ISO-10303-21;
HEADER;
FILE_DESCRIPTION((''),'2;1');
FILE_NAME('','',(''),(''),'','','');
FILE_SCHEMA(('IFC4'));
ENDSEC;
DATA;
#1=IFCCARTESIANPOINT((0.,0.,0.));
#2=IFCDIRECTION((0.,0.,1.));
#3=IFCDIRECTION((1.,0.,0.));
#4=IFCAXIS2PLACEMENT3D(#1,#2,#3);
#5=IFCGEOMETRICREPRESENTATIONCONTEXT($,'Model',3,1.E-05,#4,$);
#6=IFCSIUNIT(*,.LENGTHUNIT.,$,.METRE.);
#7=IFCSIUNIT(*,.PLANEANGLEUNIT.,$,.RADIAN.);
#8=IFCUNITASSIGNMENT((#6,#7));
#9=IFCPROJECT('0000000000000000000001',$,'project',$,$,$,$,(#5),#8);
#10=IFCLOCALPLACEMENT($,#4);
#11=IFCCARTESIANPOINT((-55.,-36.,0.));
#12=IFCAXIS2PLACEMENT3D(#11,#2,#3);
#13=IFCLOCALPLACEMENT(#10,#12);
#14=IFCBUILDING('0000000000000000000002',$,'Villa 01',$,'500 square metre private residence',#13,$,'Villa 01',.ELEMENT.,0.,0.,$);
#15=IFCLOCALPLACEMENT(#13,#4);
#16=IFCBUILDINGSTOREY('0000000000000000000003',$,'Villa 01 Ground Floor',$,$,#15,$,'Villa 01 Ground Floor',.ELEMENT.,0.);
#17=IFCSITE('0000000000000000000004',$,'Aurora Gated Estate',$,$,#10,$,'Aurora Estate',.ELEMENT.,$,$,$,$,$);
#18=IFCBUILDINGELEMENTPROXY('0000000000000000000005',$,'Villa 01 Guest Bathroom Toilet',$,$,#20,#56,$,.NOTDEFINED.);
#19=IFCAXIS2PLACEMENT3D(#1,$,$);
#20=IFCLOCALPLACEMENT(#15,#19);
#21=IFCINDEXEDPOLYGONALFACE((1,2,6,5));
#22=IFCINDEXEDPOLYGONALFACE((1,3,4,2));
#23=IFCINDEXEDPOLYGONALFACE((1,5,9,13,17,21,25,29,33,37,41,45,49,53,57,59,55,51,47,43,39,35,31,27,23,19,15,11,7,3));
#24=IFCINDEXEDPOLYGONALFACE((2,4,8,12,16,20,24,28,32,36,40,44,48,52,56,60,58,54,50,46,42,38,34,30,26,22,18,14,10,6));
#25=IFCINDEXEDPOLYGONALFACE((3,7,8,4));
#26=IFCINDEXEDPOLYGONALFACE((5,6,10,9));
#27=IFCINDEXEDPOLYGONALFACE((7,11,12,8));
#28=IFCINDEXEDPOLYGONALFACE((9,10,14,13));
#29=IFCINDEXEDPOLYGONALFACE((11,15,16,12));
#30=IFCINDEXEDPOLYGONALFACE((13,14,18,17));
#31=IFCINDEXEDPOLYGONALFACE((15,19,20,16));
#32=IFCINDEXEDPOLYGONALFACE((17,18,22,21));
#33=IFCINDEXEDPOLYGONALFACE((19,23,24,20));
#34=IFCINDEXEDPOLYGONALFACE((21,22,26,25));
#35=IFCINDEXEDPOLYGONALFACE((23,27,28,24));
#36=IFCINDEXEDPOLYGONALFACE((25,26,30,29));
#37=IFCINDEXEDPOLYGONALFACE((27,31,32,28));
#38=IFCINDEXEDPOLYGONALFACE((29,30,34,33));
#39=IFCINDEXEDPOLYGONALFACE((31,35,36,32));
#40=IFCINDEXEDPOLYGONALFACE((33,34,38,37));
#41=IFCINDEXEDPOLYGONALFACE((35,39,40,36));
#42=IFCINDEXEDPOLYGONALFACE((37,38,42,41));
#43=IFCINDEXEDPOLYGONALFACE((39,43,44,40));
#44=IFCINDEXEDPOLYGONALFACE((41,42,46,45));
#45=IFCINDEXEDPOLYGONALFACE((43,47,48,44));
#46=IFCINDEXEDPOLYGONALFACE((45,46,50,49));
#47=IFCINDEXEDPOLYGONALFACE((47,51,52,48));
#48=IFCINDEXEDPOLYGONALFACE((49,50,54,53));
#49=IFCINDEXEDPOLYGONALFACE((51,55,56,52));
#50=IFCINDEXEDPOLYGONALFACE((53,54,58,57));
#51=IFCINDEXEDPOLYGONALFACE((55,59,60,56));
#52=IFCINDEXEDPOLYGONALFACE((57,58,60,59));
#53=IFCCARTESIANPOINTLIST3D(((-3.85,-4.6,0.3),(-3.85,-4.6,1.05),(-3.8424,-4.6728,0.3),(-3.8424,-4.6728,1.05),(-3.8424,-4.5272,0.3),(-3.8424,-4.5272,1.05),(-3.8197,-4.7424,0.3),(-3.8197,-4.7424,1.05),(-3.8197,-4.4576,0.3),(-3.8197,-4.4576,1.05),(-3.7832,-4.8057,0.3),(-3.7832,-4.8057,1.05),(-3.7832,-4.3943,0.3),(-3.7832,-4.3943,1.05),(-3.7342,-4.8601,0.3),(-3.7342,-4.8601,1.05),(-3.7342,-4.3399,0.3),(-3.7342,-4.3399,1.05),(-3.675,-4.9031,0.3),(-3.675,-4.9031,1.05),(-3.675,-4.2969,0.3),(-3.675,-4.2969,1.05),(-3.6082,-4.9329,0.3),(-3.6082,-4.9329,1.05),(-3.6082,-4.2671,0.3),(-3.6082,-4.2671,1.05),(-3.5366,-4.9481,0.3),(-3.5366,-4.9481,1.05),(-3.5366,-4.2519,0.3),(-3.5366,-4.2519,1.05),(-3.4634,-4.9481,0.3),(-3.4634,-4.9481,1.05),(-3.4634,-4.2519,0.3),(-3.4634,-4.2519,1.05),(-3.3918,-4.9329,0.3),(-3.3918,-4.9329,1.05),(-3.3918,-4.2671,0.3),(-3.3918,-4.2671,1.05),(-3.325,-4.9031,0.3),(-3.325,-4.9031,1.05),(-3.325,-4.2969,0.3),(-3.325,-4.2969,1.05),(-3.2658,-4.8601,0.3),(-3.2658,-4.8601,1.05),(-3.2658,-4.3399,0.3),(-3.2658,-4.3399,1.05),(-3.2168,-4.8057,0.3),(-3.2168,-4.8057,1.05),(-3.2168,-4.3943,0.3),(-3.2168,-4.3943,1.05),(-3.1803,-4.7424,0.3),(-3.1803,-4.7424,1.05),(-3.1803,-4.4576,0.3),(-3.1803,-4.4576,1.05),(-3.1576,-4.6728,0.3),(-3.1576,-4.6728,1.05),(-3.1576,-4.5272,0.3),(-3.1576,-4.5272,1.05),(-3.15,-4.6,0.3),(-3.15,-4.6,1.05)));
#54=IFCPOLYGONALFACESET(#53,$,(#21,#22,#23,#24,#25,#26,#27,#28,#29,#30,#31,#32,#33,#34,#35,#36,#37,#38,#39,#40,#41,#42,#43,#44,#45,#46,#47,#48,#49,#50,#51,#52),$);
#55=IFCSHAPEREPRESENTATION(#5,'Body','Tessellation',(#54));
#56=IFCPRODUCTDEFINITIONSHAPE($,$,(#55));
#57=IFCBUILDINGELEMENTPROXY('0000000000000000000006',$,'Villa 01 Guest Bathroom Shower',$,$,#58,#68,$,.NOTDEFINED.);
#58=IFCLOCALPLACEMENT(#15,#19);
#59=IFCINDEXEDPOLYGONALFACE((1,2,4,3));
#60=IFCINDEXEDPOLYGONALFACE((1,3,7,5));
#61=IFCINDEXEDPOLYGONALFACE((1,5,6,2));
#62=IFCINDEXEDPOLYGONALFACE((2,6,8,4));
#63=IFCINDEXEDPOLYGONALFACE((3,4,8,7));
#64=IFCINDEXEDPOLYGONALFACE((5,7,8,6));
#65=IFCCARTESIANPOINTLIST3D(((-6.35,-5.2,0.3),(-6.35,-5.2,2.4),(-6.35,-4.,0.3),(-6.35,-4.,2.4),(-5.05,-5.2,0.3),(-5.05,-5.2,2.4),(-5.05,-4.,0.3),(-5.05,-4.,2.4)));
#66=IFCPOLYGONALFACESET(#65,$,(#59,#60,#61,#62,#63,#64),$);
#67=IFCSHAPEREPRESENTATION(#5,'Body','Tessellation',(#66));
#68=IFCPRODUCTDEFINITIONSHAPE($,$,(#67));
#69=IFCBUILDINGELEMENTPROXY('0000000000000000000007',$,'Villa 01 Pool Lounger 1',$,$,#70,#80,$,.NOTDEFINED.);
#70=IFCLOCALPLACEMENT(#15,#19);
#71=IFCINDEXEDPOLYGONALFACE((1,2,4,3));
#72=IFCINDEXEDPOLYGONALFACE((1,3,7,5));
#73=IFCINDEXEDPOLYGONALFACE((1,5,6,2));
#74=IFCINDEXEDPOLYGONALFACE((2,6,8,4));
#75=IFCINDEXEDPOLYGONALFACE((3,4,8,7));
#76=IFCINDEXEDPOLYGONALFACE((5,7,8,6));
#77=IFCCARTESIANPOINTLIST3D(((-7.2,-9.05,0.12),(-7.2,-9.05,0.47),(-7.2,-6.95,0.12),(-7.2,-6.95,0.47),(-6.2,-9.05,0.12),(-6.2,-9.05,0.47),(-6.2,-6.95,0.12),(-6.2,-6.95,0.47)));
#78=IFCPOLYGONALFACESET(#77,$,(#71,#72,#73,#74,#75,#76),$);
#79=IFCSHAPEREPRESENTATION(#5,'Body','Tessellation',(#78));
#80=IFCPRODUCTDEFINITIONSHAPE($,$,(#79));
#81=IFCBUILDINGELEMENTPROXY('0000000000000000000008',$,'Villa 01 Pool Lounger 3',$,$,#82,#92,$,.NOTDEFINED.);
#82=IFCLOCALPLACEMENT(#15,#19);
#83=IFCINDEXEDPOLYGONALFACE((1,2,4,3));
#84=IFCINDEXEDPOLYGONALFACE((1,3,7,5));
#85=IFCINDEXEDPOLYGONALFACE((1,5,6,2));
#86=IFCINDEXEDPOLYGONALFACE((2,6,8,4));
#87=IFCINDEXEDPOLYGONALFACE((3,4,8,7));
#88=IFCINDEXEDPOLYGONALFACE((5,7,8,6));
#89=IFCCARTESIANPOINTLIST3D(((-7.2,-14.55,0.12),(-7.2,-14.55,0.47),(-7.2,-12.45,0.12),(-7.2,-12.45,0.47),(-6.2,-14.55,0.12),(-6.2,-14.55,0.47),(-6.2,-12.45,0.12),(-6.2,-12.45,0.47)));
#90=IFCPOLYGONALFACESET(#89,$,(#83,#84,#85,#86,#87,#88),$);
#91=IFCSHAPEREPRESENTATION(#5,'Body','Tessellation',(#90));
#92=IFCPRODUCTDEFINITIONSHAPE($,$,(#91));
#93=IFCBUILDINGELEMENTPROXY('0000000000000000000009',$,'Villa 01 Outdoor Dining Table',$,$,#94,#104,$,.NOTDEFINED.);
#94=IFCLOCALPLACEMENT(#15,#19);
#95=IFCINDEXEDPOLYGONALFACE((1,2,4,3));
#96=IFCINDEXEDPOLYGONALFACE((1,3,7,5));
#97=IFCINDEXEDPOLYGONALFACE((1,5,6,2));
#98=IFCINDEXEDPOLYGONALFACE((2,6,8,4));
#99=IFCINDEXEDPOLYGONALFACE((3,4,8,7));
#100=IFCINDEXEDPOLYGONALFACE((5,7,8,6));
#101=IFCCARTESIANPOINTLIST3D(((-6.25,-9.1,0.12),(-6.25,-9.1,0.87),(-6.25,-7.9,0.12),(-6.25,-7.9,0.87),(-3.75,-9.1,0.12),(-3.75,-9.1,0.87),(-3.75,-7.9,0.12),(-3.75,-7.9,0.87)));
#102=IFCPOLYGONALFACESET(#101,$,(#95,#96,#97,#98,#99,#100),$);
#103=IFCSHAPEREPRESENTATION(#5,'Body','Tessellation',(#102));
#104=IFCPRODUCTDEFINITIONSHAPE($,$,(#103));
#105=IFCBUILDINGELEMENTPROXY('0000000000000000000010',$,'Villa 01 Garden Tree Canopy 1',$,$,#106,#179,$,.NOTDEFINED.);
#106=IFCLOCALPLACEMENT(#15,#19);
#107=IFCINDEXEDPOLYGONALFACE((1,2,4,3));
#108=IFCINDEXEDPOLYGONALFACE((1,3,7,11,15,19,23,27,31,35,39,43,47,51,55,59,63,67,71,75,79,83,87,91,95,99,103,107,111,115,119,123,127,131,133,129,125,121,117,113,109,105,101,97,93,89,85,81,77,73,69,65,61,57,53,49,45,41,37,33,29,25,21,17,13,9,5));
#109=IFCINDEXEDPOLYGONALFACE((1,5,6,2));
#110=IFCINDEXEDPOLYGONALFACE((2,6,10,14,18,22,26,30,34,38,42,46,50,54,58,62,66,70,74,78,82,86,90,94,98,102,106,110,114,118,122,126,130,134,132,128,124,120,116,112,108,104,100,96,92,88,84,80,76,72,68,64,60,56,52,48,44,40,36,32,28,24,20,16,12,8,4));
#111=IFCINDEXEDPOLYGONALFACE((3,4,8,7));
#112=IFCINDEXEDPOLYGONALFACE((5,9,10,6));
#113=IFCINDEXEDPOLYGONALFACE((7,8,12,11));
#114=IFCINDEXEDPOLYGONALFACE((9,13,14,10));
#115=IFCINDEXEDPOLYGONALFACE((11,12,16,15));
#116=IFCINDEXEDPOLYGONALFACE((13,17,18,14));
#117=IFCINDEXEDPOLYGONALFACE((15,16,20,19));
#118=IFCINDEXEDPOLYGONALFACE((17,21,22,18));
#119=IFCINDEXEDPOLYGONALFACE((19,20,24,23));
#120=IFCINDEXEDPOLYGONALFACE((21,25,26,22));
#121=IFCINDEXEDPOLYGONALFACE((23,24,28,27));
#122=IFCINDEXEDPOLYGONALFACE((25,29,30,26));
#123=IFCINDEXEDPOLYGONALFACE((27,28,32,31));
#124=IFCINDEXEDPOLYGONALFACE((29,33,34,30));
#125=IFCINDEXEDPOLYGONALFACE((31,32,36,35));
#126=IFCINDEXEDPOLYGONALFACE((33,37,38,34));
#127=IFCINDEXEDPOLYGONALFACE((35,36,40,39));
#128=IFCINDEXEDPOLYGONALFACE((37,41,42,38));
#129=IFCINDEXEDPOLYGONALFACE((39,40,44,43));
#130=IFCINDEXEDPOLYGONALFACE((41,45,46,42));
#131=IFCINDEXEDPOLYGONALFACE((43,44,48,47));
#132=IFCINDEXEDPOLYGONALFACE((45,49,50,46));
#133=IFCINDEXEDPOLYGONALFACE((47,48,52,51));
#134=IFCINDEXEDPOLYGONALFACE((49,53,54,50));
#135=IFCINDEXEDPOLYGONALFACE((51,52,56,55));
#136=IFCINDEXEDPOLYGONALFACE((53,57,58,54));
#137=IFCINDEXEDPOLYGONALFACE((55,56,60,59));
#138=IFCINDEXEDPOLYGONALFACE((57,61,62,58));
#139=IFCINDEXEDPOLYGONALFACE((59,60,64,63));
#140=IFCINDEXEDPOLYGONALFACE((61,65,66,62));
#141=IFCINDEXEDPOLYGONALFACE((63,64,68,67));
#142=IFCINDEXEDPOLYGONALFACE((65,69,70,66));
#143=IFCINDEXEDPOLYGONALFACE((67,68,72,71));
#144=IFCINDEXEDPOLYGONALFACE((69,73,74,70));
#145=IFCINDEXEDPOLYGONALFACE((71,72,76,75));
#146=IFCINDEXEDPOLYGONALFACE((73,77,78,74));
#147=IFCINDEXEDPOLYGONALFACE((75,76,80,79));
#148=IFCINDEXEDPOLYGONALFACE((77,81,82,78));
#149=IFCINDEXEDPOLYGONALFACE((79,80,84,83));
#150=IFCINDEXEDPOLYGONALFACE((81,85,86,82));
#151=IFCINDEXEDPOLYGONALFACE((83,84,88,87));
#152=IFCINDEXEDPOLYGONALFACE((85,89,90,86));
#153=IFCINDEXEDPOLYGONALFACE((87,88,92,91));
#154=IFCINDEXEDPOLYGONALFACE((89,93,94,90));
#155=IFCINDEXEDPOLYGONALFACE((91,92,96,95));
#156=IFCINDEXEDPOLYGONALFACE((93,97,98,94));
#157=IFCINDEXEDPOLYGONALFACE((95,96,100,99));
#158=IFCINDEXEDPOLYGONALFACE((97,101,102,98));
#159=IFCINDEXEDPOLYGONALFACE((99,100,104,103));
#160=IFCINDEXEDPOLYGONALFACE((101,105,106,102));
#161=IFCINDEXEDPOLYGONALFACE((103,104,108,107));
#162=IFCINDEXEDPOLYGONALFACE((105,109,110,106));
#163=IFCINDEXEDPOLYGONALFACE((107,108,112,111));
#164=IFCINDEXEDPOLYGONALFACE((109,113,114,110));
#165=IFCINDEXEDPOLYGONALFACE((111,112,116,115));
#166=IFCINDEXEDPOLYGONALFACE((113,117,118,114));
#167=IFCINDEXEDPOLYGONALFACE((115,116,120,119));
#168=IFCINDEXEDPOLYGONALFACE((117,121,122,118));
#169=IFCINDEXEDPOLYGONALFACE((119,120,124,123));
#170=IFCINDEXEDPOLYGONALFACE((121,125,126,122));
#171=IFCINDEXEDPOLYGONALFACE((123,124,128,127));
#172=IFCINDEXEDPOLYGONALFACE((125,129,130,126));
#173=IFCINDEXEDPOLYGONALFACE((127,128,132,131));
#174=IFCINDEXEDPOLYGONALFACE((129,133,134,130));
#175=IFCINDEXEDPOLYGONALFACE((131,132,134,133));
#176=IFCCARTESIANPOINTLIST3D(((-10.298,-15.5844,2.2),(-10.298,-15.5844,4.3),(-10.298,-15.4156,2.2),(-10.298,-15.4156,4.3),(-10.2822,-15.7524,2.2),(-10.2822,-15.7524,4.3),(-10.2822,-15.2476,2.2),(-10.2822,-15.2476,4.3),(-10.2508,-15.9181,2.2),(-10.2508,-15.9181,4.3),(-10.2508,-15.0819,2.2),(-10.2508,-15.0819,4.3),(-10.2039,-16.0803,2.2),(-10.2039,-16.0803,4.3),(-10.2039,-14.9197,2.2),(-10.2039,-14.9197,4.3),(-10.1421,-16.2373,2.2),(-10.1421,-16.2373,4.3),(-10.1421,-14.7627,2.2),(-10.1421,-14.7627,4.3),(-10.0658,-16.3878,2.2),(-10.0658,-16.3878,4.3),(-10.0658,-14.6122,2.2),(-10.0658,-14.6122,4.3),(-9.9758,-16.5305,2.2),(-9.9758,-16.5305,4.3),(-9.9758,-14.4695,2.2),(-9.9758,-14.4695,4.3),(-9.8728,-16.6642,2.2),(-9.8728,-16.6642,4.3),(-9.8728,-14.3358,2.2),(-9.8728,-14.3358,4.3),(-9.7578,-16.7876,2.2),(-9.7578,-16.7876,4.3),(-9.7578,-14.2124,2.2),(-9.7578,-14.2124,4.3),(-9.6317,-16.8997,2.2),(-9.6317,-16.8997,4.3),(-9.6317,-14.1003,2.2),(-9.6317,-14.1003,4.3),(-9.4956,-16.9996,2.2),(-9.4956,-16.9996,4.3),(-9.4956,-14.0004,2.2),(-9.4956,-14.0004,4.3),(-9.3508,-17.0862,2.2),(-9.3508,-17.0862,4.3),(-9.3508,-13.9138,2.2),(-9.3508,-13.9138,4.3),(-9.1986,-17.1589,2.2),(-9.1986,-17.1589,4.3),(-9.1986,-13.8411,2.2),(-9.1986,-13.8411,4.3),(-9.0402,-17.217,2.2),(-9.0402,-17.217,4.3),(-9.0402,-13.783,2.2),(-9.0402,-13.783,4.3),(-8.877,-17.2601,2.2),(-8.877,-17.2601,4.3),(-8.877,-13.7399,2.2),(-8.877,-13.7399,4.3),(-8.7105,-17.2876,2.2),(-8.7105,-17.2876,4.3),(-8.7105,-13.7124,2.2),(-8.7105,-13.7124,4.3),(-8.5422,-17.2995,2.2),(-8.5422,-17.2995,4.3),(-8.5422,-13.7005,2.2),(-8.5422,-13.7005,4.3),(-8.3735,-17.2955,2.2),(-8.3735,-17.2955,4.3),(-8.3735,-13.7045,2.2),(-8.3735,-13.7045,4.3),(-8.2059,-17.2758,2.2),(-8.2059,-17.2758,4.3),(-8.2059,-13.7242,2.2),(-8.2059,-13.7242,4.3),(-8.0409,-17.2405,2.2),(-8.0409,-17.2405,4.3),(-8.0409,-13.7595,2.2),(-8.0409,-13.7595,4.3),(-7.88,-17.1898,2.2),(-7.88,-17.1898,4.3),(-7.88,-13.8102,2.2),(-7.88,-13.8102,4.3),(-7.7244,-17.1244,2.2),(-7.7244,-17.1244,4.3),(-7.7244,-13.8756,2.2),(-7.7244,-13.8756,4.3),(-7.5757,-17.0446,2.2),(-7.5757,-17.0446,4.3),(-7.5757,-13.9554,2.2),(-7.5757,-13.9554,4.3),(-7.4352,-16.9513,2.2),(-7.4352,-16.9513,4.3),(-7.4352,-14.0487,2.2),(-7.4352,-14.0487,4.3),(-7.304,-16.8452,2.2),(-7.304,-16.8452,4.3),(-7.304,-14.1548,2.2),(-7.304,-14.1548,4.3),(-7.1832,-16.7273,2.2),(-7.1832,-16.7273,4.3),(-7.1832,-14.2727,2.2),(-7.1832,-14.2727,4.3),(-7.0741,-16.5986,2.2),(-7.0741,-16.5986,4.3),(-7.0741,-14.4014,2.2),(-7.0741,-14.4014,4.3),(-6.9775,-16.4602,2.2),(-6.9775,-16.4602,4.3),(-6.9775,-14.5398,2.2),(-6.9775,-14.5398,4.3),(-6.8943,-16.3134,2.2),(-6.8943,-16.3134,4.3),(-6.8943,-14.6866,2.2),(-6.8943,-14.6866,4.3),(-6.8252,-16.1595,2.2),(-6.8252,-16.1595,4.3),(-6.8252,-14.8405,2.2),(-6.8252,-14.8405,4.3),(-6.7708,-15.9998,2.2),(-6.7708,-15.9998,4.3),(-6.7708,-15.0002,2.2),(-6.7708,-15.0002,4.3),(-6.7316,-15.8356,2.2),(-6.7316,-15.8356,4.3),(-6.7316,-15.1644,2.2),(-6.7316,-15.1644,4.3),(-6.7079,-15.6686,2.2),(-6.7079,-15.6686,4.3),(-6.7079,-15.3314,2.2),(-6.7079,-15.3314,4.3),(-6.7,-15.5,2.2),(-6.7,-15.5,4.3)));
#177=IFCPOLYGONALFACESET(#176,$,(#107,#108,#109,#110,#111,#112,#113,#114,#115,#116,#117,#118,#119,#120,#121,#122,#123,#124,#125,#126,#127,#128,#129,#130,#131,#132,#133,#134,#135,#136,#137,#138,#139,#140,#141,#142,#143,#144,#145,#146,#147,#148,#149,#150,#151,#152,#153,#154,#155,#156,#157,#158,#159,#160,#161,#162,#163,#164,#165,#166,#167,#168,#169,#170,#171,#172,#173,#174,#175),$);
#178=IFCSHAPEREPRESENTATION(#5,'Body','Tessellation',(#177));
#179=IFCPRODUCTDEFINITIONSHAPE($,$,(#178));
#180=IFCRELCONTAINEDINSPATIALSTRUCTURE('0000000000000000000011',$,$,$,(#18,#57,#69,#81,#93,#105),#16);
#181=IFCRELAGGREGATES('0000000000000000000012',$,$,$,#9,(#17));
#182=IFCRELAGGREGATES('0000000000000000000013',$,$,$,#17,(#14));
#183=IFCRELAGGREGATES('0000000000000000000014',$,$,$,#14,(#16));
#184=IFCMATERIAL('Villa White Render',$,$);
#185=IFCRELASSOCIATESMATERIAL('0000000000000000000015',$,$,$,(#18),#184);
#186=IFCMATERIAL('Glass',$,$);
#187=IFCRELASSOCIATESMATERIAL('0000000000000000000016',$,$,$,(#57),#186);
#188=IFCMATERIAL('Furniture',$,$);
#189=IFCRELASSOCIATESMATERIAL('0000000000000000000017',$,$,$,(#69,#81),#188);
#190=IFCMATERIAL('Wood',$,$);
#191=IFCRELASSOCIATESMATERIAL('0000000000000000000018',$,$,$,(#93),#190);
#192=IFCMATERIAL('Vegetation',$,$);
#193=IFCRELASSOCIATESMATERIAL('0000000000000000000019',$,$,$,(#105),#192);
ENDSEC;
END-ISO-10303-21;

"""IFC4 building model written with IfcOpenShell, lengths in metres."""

from ifc_helpers import new_model, si_unit, frame, origin_with_axes, origin_2d_with_axis, place, context, project, spatial, rectangle, circle, extrude, material, element, save


model = new_model("IFC4")

# Units and contexts
model_context = context("Model", 3, precision=1e-05, world=origin_with_axes())
ifc_project = project(units=[si_unit("LENGTHUNIT", "METRE"), si_unit("PLANEANGLEUNIT", "RADIAN")], contexts=[model_context])

# Site, building, storey
site_placement = place(None, origin_with_axes())
site = spatial("IfcSite", under=ifc_project, at=site_placement, Name="Aurora Gated Estate", LongName="Aurora Estate", CompositionType="ELEMENT")
building_placement = place(site_placement, frame((-55.0, -36.0, 0.0), z_axis=(0.0, 0.0, 1.0), x_axis=(1.0, 0.0, 0.0)))
building = spatial("IfcBuilding", under=site, at=building_placement, Name="Villa 01", ObjectType="500 square metre private residence", LongName="Villa 01", CompositionType="ELEMENT", ElevationOfRefHeight=0.0, ElevationOfTerrain=0.0)
storey_placement = place(building_placement, origin_with_axes())
storey = spatial("IfcBuildingStorey", under=building, at=storey_placement, Name="Villa 01 Ground Floor", LongName="Villa 01 Ground Floor", CompositionType="ELEMENT", Elevation=0.0)

# Shared definitions
ifc_material_1 = material(Name="Wood")

# Building element proxies
ifc_material_2 = material(Name="Furniture")
ifc_material_3 = material(Name="Villa White Render")
proxy_1_placement = place(storey_placement, frame((-3.5, -4.6, 0.3), z_axis=(0.0, 0.0, 1.0), x_axis=(1.0, 0.0, 0.0)))
element("IfcBuildingElementProxy", 1, at=proxy_1_placement, inside=storey, material=ifc_material_3, Name="Villa 01 Guest Bathroom Toilet", PredefinedType="NOTDEFINED", context=model_context, shape_type="SweptSolid", body=[
    extrude(circle(Radius=0.35, at=origin_2d_with_axis()), origin_with_axes(), (0.0, 0.0, 1.0), 0.75),
])
ifc_material_4 = material(Name="Glass")
proxy_2_placement = place(storey_placement, frame((-5.7, -4.6, 0.3), z_axis=(0.0, 0.0, 1.0), x_axis=(1.0, 0.0, 0.0)))
element("IfcBuildingElementProxy", 2, at=proxy_2_placement, inside=storey, material=ifc_material_4, Name="Villa 01 Guest Bathroom Shower", PredefinedType="NOTDEFINED", context=model_context, shape_type="SweptSolid", body=[
    extrude(rectangle(XDim=1.3, YDim=1.2, at=origin_2d_with_axis()), origin_with_axes(), (0.0, 0.0, 1.0), 2.1),
])
for number, where, z_axis, x_axis, name in (
    (3, (-6.7, -8.0, 0.12), (0.0, 0.0, 1.0), (1.0, 0.0, 0.0), "Villa 01 Pool Lounger 1"),
    (4, (-6.7, -13.5, 0.12), (0.0, 0.0, 1.0), (1.0, 0.0, 0.0), "Villa 01 Pool Lounger 3"),
):
    element("IfcBuildingElementProxy", number, at=place(storey_placement, frame(where, z_axis=z_axis, x_axis=x_axis)), inside=storey, material=ifc_material_2, Name=name, PredefinedType="NOTDEFINED", context=model_context, shape_type="SweptSolid", body=[
        extrude(rectangle(XDim=1.0, YDim=2.1, at=origin_2d_with_axis()), origin_with_axes(), (0.0, 0.0, 1.0), 0.35),
    ])
proxy_3_placement = place(storey_placement, frame((-5.0, -8.5, 0.12), z_axis=(0.0, 0.0, 1.0), x_axis=(1.0, 0.0, 0.0)))
element("IfcBuildingElementProxy", 5, at=proxy_3_placement, inside=storey, material=ifc_material_1, Name="Villa 01 Outdoor Dining Table", PredefinedType="NOTDEFINED", context=model_context, shape_type="SweptSolid", body=[
    extrude(rectangle(XDim=2.5, YDim=1.2, at=origin_2d_with_axis()), origin_with_axes(), (0.0, 0.0, 1.0), 0.75),
])
ifc_material_5 = material(Name="Vegetation")
proxy_4_placement = place(storey_placement, frame((-8.5, -15.5, 2.2), z_axis=(0.0, 0.0, 1.0), x_axis=(1.0, 0.0, 0.0)))
element("IfcBuildingElementProxy", 6, at=proxy_4_placement, inside=storey, material=ifc_material_5, Name="Villa 01 Garden Tree Canopy 1", PredefinedType="NOTDEFINED", context=model_context, shape_type="SweptSolid", body=[
    extrude(circle(Radius=1.8, at=origin_2d_with_axis()), origin_with_axes(), (0.0, 0.0, 1.0), 2.1),
])

save(model, "model.ifc")
